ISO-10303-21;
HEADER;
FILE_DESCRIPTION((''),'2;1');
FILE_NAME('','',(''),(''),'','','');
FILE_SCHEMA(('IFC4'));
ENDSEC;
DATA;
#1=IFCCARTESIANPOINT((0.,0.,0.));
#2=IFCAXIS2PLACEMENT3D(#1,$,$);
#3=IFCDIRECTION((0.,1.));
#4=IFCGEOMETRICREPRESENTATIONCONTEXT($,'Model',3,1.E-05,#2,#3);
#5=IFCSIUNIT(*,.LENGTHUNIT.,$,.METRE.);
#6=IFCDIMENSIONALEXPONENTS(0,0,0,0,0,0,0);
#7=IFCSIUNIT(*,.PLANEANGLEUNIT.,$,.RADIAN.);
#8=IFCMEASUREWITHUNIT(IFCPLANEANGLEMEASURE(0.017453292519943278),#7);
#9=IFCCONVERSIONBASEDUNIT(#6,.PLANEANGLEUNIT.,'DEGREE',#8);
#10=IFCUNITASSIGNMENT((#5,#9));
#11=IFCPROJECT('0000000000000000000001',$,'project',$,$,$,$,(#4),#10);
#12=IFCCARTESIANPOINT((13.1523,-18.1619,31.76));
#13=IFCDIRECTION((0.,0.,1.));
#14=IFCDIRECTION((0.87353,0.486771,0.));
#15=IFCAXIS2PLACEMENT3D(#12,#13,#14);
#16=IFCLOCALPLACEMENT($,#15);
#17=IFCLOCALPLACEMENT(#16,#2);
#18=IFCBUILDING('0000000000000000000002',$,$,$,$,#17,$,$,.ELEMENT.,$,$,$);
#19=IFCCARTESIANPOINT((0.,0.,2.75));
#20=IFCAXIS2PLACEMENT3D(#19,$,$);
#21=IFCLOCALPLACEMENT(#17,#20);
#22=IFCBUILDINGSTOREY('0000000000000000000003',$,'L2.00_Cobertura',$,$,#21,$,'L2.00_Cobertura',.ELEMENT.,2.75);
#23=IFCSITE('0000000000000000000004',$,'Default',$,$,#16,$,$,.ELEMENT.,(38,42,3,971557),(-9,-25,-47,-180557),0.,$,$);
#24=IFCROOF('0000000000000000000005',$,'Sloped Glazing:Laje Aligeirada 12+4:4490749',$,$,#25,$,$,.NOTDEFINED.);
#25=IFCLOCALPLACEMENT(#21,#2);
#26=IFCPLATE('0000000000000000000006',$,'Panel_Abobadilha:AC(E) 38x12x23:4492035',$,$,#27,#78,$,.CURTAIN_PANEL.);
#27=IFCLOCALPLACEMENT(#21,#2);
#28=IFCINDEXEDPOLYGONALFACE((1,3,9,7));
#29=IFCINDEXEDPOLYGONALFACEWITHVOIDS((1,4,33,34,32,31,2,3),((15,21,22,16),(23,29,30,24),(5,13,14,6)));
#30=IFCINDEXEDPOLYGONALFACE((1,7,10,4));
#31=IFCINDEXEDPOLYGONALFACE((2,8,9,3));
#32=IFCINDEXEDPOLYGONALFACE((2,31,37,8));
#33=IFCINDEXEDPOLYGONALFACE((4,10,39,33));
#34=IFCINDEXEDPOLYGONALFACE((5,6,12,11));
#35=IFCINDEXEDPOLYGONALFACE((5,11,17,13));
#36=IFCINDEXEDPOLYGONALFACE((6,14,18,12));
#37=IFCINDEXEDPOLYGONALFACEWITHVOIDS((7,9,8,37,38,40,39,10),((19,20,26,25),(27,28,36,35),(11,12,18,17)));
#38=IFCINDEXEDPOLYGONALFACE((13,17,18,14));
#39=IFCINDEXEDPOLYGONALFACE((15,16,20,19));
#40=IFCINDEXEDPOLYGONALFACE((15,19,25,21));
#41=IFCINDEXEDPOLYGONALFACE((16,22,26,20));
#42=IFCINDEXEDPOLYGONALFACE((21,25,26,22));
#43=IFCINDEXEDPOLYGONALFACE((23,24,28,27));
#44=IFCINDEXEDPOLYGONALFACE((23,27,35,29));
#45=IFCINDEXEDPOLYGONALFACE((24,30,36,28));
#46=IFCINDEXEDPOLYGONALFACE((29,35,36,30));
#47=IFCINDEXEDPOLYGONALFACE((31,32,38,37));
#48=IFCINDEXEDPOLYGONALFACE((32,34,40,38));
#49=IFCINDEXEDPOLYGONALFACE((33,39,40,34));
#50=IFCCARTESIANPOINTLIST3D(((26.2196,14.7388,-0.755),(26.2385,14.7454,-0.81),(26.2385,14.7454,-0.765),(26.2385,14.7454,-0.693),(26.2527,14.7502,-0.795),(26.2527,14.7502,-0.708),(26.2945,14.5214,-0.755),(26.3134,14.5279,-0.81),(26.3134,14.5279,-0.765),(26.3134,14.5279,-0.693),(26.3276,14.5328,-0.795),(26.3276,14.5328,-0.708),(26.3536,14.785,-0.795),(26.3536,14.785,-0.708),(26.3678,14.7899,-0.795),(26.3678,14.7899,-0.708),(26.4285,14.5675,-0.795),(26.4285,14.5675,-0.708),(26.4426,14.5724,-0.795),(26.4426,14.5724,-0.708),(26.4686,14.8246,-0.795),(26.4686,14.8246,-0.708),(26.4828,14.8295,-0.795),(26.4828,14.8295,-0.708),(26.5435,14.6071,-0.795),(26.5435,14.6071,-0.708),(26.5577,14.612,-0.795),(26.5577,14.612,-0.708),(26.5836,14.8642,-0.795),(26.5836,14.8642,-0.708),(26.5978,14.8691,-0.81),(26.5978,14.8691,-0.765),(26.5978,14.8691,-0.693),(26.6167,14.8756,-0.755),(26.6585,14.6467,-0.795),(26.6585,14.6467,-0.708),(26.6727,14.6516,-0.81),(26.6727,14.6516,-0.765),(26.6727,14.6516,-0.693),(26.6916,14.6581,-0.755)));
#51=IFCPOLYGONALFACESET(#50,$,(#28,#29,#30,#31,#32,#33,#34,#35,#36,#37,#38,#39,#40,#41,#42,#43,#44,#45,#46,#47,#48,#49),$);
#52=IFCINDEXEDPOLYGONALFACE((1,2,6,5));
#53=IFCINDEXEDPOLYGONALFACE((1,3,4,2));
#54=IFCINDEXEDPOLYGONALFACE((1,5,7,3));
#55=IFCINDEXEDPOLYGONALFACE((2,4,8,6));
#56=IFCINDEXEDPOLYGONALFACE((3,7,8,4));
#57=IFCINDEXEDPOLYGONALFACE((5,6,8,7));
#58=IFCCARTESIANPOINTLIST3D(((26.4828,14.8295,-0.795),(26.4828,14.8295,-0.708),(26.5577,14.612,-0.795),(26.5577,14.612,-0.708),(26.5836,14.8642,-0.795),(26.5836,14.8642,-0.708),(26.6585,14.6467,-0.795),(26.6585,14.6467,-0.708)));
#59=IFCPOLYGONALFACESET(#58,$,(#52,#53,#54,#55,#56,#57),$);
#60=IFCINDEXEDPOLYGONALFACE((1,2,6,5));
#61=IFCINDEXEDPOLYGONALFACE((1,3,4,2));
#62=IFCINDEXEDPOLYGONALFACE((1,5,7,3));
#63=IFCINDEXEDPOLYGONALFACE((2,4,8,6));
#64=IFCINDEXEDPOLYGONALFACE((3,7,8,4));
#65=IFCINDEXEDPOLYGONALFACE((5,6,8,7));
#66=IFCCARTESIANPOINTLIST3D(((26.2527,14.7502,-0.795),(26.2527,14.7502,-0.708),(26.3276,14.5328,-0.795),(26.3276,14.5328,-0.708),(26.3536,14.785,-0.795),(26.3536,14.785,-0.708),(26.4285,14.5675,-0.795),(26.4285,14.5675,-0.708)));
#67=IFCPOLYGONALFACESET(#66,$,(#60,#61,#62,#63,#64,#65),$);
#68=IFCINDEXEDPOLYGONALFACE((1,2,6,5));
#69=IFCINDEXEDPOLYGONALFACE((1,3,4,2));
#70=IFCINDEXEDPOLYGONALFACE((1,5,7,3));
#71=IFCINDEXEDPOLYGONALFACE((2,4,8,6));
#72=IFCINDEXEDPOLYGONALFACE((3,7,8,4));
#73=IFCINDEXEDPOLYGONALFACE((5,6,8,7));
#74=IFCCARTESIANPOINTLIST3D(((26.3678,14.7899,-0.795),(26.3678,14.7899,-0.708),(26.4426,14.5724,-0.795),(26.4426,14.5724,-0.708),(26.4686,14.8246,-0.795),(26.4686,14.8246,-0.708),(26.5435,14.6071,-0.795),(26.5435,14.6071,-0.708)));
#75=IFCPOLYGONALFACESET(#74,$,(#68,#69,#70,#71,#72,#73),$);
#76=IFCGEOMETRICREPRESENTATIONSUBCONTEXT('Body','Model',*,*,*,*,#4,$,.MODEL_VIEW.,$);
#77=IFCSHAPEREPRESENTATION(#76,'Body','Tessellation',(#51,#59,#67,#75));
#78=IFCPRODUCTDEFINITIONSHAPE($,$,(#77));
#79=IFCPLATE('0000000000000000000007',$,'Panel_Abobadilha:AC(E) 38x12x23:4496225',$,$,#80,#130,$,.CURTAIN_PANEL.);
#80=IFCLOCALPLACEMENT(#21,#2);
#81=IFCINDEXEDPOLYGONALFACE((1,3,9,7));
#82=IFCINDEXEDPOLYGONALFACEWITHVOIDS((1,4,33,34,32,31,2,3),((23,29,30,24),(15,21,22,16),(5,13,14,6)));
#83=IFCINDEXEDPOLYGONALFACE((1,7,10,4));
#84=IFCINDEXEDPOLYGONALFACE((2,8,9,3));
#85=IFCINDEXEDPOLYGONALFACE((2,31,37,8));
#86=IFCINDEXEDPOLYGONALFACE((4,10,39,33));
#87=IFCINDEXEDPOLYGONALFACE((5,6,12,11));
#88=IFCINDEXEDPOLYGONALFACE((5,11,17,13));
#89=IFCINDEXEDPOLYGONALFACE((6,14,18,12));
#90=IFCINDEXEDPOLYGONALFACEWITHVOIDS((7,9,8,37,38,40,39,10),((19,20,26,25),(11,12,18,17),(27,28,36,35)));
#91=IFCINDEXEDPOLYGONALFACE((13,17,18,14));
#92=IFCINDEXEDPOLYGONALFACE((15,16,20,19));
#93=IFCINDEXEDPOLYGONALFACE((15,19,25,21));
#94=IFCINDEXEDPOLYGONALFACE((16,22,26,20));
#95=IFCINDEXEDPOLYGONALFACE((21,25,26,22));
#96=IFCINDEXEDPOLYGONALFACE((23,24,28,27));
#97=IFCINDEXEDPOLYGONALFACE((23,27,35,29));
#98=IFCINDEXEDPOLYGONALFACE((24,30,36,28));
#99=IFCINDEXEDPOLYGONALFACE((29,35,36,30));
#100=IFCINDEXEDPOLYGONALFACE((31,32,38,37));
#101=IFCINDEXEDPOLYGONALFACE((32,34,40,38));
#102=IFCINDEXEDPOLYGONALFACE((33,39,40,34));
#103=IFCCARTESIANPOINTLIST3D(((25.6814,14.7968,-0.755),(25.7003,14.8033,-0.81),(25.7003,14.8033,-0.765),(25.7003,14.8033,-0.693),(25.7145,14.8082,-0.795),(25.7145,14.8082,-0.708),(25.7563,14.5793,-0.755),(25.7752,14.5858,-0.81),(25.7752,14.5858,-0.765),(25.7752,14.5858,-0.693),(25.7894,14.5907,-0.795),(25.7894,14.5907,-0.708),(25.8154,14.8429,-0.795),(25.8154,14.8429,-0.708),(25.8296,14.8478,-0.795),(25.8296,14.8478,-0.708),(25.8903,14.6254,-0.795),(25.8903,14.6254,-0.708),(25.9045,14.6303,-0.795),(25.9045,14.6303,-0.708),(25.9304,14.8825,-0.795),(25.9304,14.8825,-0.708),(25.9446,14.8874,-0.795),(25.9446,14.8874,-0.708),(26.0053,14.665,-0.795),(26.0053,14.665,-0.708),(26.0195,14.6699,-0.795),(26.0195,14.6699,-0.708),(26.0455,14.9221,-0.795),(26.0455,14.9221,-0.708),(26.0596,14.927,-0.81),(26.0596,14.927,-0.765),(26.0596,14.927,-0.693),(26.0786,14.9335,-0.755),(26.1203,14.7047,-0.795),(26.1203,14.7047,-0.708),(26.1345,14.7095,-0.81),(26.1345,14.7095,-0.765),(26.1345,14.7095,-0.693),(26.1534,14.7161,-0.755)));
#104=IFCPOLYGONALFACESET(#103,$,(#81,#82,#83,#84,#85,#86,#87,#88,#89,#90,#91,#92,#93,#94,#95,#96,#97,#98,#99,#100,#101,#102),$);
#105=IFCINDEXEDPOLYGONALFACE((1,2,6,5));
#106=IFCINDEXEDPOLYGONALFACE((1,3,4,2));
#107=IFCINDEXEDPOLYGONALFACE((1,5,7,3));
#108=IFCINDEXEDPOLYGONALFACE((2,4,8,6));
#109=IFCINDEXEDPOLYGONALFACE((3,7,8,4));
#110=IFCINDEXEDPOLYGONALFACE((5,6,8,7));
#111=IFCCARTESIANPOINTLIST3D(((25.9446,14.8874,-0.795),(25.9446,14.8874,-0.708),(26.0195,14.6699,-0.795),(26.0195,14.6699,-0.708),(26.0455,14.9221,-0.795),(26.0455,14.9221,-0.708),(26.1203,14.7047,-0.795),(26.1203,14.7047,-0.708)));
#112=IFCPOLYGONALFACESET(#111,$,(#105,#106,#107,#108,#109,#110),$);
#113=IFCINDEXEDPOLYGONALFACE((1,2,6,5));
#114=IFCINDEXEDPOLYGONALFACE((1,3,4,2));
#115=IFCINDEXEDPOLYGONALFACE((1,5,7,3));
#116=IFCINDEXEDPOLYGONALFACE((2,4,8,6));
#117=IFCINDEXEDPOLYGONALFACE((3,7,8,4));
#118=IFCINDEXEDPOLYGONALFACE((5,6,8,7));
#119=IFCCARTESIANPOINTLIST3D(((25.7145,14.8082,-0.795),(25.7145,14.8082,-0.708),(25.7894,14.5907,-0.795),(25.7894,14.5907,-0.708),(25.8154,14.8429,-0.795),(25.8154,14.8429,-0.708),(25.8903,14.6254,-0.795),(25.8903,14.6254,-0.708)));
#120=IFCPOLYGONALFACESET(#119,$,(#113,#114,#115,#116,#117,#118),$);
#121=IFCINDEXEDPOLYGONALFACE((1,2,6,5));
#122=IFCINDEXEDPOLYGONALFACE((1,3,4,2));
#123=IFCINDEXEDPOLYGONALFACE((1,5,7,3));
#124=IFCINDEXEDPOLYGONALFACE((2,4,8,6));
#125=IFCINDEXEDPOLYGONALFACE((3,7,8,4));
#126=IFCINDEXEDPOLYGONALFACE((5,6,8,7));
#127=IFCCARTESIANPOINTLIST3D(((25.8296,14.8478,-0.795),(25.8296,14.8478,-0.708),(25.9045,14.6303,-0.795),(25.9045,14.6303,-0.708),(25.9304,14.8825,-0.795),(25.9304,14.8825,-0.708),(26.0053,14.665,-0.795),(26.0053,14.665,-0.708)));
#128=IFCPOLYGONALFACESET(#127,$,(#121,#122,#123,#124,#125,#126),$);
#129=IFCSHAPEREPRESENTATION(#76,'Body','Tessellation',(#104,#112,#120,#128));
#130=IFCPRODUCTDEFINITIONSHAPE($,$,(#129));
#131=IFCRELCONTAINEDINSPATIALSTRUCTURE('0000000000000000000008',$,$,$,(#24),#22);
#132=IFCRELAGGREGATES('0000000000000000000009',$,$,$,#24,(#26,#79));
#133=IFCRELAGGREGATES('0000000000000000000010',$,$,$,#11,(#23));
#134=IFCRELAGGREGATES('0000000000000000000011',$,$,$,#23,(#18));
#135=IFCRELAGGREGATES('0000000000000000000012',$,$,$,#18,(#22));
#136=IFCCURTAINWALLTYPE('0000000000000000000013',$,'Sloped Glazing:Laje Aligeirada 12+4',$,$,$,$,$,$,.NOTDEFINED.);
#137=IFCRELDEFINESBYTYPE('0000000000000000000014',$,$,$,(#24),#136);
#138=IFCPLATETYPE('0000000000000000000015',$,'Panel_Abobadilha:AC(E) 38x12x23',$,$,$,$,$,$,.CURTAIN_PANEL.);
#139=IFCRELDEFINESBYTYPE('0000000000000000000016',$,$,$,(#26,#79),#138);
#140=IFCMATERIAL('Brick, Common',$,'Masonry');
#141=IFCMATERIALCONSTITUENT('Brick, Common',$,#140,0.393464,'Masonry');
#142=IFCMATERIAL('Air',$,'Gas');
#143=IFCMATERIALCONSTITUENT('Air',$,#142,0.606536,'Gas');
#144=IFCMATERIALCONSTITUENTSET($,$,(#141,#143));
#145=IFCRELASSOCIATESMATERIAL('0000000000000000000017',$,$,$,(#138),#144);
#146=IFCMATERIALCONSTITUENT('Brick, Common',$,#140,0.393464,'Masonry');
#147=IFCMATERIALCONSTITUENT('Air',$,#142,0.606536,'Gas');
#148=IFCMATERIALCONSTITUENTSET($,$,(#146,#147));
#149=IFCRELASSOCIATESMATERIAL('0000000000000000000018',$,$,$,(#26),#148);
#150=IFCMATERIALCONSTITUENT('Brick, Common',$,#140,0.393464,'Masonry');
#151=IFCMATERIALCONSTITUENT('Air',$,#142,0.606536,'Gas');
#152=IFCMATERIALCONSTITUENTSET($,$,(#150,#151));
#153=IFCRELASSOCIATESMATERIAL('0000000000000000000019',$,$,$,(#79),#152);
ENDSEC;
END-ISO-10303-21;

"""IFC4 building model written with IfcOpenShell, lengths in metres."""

from ifc_helpers import new_model, entity, si_unit, converted_unit, direction, frame, origin, place, context, subcontext, project, spatial, indexed_curve, outline, extrude, source, transform, mapped, material, constituent, constituent_set, type_object, type_shapes, element, aggregate, save


model = new_model("IFC4")

# Units and contexts
model_context = context("Model", 3, precision=1e-05, world=origin(), true_north=direction((0.0, 1.0)))
body_context = subcontext(model_context, "Body", "Model", "MODEL_VIEW")
ifc_project = project(units=[si_unit("LENGTHUNIT", "METRE"), converted_unit("PLANEANGLEUNIT", "DEGREE", entity("IfcPlaneAngleMeasure", 0.017453292519943278), si_unit("PLANEANGLEUNIT", "RADIAN"), dimensions=[0, 0, 0, 0, 0, 0, 0])], contexts=[model_context])

# Site, building, storey
site_placement = place(None, frame((13.1523, -18.1619, 31.76), z_axis=(0.0, 0.0, 1.0), x_axis=(0.87353, 0.486771, 0.0)))
site = spatial("IfcSite", under=ifc_project, at=site_placement, Name="Default", CompositionType="ELEMENT", RefLatitude=(38, 42, 3, 971557), RefLongitude=(-9, -25, -47, -180557), RefElevation=0.0)
building_placement = place(site_placement, origin())
building = spatial("IfcBuilding", under=site, at=building_placement, CompositionType="ELEMENT")
storey_placement = place(building_placement, frame((0.0, 0.0, 2.75)))
storey = spatial("IfcBuildingStorey", under=building, at=storey_placement, Name="L2.00_Cobertura", LongName="L2.00_Cobertura", CompositionType="ELEMENT", Elevation=2.75)

# Roof, plates
curtain_wall_type = type_object("IfcCurtainWallType", Name="Sloped Glazing:Laje Aligeirada 12+4", PredefinedType="NOTDEFINED")
roof_placement = place(storey_placement, frame((0.0, 0.0, -2.75)))
roof = element("IfcRoof", 1, at=roof_placement, inside=storey, type_object=curtain_wall_type, Name="Sloped Glazing:Laje Aligeirada 12+4:4490749", PredefinedType="NOTDEFINED")
ifc_material_1 = material(Name="Brick, Common", Category="Masonry")
ifc_material_2 = material(Name="Air", Category="Gas")
ifc_constituent_1 = constituent(ifc_material_1, Name="Brick, Common", Category="Masonry", fraction=0.393464)
ifc_constituent_2 = constituent(ifc_material_2, Name="Air", Category="Gas", fraction=0.606536)
ifc_constituent_set_1 = constituent_set(constituents=[ifc_constituent_1, ifc_constituent_2])
plate_type = type_object("IfcPlateType", Name="Panel_Abobadilha:AC(E) 38x12x23", PredefinedType="CURTAIN_PANEL", material=ifc_constituent_set_1)
shared_shape_1 = source(origin(), body_context, "Body", "SweptSolid", [
    extrude(outline(indexed_curve([(-0.19, -0.0543), (0.19, -0.0543), (0.19, -0.0093), (0.21, 0.0007), (0.19, 0.0628), (-0.19, 0.0628), (-0.21, 0.0007), (-0.19, -0.0093), (-0.19, -0.0543)], self_intersect=False), holes=[indexed_curve([(-0.0683, 0.0477), (-0.0683, -0.0393), (-0.175, -0.0393), (-0.175, 0.0477), (-0.0683, 0.0477)], self_intersect=False), indexed_curve([(0.0533, 0.0477), (0.0533, -0.0393), (-0.0533, -0.0393), (-0.0533, 0.0477), (0.0533, 0.0477)], self_intersect=False), indexed_curve([(0.175, 0.0477), (0.175, -0.0393), (0.0683, -0.0393), (0.0683, 0.0477), (0.175, 0.0477)], self_intersect=False)]), frame((0.0, 0.0543, 0.0)), (0.0, 0.0, 1.0), 0.23),
    extrude(outline(indexed_curve([(-0.0533, -0.0435), (0.0533, -0.0435), (0.0533, 0.0435), (-0.0533, 0.0435), (-0.0533, -0.0435)], self_intersect=False)), frame((0.1217, 0.0585, 0.0), z_axis=(0.0, 0.0, 1.0), x_axis=(-1.0, 0.0, 0.0)), (0.0, 0.0, 1.0), 0.23),
    extrude(outline(indexed_curve([(-0.0533, -0.0435), (0.0533, -0.0435), (0.0533, 0.0435), (-0.0533, 0.0435), (-0.0533, -0.0435)], self_intersect=False)), frame((-0.1217, 0.0585, 0.0), z_axis=(0.0, 0.0, 1.0), x_axis=(-1.0, 0.0, 0.0)), (0.0, 0.0, 1.0), 0.23),
    extrude(outline(indexed_curve([(-0.0533, -0.0435), (0.0533, -0.0435), (0.0533, 0.0435), (-0.0533, 0.0435), (-0.0533, -0.0435)], self_intersect=False)), frame((0.0, 0.0585, 0.0), z_axis=(0.0, 0.0, 1.0), x_axis=(-1.0, 0.0, 0.0)), (0.0, 0.0, 1.0), 0.23),
])
type_shapes(plate_type, [shared_shape_1])
ifc_constituent_3 = constituent(ifc_material_1, Name="Brick, Common", Category="Masonry", fraction=0.393464)
ifc_constituent_4 = constituent(ifc_material_2, Name="Air", Category="Gas", fraction=0.606536)
ifc_constituent_set_2 = constituent_set(constituents=[ifc_constituent_3, ifc_constituent_4])
plate_1_placement = place(roof_placement, frame((26.4182, 14.8072, 1.94), z_axis=(0.325568, -0.945519, 0.0), x_axis=(0.945519, 0.325568, 0.0)))
plate_1 = element("IfcPlate", 2, at=plate_1_placement, type_object=plate_type, material=ifc_constituent_set_2, Name="Panel_Abobadilha:AC(E) 38x12x23:4492035", PredefinedType="CURTAIN_PANEL", context=body_context, shape_type="MappedRepresentation", body=[
    mapped(shared_shape_1, transform((0.0, 0.0, 0.0), scale=1.0)),
])
ifc_constituent_5 = constituent(ifc_material_1, Name="Brick, Common", Category="Masonry", fraction=0.393464)
ifc_constituent_6 = constituent(ifc_material_2, Name="Air", Category="Gas", fraction=0.606536)
ifc_constituent_set_3 = constituent_set(constituents=[ifc_constituent_5, ifc_constituent_6])
plate_2_placement = place(roof_placement, frame((25.88, 14.8652, 1.94), z_axis=(0.325568, -0.945519, 0.0), x_axis=(0.945519, 0.325568, 0.0)))
plate_2 = element("IfcPlate", 3, at=plate_2_placement, type_object=plate_type, material=ifc_constituent_set_3, Name="Panel_Abobadilha:AC(E) 38x12x23:4496225", PredefinedType="CURTAIN_PANEL", context=body_context, shape_type="MappedRepresentation", body=[
    mapped(shared_shape_1, transform((0.0, 0.0, 0.0), scale=1.0)),
])
aggregate(roof, [plate_1, plate_2])

save(model, "model.ifc")
